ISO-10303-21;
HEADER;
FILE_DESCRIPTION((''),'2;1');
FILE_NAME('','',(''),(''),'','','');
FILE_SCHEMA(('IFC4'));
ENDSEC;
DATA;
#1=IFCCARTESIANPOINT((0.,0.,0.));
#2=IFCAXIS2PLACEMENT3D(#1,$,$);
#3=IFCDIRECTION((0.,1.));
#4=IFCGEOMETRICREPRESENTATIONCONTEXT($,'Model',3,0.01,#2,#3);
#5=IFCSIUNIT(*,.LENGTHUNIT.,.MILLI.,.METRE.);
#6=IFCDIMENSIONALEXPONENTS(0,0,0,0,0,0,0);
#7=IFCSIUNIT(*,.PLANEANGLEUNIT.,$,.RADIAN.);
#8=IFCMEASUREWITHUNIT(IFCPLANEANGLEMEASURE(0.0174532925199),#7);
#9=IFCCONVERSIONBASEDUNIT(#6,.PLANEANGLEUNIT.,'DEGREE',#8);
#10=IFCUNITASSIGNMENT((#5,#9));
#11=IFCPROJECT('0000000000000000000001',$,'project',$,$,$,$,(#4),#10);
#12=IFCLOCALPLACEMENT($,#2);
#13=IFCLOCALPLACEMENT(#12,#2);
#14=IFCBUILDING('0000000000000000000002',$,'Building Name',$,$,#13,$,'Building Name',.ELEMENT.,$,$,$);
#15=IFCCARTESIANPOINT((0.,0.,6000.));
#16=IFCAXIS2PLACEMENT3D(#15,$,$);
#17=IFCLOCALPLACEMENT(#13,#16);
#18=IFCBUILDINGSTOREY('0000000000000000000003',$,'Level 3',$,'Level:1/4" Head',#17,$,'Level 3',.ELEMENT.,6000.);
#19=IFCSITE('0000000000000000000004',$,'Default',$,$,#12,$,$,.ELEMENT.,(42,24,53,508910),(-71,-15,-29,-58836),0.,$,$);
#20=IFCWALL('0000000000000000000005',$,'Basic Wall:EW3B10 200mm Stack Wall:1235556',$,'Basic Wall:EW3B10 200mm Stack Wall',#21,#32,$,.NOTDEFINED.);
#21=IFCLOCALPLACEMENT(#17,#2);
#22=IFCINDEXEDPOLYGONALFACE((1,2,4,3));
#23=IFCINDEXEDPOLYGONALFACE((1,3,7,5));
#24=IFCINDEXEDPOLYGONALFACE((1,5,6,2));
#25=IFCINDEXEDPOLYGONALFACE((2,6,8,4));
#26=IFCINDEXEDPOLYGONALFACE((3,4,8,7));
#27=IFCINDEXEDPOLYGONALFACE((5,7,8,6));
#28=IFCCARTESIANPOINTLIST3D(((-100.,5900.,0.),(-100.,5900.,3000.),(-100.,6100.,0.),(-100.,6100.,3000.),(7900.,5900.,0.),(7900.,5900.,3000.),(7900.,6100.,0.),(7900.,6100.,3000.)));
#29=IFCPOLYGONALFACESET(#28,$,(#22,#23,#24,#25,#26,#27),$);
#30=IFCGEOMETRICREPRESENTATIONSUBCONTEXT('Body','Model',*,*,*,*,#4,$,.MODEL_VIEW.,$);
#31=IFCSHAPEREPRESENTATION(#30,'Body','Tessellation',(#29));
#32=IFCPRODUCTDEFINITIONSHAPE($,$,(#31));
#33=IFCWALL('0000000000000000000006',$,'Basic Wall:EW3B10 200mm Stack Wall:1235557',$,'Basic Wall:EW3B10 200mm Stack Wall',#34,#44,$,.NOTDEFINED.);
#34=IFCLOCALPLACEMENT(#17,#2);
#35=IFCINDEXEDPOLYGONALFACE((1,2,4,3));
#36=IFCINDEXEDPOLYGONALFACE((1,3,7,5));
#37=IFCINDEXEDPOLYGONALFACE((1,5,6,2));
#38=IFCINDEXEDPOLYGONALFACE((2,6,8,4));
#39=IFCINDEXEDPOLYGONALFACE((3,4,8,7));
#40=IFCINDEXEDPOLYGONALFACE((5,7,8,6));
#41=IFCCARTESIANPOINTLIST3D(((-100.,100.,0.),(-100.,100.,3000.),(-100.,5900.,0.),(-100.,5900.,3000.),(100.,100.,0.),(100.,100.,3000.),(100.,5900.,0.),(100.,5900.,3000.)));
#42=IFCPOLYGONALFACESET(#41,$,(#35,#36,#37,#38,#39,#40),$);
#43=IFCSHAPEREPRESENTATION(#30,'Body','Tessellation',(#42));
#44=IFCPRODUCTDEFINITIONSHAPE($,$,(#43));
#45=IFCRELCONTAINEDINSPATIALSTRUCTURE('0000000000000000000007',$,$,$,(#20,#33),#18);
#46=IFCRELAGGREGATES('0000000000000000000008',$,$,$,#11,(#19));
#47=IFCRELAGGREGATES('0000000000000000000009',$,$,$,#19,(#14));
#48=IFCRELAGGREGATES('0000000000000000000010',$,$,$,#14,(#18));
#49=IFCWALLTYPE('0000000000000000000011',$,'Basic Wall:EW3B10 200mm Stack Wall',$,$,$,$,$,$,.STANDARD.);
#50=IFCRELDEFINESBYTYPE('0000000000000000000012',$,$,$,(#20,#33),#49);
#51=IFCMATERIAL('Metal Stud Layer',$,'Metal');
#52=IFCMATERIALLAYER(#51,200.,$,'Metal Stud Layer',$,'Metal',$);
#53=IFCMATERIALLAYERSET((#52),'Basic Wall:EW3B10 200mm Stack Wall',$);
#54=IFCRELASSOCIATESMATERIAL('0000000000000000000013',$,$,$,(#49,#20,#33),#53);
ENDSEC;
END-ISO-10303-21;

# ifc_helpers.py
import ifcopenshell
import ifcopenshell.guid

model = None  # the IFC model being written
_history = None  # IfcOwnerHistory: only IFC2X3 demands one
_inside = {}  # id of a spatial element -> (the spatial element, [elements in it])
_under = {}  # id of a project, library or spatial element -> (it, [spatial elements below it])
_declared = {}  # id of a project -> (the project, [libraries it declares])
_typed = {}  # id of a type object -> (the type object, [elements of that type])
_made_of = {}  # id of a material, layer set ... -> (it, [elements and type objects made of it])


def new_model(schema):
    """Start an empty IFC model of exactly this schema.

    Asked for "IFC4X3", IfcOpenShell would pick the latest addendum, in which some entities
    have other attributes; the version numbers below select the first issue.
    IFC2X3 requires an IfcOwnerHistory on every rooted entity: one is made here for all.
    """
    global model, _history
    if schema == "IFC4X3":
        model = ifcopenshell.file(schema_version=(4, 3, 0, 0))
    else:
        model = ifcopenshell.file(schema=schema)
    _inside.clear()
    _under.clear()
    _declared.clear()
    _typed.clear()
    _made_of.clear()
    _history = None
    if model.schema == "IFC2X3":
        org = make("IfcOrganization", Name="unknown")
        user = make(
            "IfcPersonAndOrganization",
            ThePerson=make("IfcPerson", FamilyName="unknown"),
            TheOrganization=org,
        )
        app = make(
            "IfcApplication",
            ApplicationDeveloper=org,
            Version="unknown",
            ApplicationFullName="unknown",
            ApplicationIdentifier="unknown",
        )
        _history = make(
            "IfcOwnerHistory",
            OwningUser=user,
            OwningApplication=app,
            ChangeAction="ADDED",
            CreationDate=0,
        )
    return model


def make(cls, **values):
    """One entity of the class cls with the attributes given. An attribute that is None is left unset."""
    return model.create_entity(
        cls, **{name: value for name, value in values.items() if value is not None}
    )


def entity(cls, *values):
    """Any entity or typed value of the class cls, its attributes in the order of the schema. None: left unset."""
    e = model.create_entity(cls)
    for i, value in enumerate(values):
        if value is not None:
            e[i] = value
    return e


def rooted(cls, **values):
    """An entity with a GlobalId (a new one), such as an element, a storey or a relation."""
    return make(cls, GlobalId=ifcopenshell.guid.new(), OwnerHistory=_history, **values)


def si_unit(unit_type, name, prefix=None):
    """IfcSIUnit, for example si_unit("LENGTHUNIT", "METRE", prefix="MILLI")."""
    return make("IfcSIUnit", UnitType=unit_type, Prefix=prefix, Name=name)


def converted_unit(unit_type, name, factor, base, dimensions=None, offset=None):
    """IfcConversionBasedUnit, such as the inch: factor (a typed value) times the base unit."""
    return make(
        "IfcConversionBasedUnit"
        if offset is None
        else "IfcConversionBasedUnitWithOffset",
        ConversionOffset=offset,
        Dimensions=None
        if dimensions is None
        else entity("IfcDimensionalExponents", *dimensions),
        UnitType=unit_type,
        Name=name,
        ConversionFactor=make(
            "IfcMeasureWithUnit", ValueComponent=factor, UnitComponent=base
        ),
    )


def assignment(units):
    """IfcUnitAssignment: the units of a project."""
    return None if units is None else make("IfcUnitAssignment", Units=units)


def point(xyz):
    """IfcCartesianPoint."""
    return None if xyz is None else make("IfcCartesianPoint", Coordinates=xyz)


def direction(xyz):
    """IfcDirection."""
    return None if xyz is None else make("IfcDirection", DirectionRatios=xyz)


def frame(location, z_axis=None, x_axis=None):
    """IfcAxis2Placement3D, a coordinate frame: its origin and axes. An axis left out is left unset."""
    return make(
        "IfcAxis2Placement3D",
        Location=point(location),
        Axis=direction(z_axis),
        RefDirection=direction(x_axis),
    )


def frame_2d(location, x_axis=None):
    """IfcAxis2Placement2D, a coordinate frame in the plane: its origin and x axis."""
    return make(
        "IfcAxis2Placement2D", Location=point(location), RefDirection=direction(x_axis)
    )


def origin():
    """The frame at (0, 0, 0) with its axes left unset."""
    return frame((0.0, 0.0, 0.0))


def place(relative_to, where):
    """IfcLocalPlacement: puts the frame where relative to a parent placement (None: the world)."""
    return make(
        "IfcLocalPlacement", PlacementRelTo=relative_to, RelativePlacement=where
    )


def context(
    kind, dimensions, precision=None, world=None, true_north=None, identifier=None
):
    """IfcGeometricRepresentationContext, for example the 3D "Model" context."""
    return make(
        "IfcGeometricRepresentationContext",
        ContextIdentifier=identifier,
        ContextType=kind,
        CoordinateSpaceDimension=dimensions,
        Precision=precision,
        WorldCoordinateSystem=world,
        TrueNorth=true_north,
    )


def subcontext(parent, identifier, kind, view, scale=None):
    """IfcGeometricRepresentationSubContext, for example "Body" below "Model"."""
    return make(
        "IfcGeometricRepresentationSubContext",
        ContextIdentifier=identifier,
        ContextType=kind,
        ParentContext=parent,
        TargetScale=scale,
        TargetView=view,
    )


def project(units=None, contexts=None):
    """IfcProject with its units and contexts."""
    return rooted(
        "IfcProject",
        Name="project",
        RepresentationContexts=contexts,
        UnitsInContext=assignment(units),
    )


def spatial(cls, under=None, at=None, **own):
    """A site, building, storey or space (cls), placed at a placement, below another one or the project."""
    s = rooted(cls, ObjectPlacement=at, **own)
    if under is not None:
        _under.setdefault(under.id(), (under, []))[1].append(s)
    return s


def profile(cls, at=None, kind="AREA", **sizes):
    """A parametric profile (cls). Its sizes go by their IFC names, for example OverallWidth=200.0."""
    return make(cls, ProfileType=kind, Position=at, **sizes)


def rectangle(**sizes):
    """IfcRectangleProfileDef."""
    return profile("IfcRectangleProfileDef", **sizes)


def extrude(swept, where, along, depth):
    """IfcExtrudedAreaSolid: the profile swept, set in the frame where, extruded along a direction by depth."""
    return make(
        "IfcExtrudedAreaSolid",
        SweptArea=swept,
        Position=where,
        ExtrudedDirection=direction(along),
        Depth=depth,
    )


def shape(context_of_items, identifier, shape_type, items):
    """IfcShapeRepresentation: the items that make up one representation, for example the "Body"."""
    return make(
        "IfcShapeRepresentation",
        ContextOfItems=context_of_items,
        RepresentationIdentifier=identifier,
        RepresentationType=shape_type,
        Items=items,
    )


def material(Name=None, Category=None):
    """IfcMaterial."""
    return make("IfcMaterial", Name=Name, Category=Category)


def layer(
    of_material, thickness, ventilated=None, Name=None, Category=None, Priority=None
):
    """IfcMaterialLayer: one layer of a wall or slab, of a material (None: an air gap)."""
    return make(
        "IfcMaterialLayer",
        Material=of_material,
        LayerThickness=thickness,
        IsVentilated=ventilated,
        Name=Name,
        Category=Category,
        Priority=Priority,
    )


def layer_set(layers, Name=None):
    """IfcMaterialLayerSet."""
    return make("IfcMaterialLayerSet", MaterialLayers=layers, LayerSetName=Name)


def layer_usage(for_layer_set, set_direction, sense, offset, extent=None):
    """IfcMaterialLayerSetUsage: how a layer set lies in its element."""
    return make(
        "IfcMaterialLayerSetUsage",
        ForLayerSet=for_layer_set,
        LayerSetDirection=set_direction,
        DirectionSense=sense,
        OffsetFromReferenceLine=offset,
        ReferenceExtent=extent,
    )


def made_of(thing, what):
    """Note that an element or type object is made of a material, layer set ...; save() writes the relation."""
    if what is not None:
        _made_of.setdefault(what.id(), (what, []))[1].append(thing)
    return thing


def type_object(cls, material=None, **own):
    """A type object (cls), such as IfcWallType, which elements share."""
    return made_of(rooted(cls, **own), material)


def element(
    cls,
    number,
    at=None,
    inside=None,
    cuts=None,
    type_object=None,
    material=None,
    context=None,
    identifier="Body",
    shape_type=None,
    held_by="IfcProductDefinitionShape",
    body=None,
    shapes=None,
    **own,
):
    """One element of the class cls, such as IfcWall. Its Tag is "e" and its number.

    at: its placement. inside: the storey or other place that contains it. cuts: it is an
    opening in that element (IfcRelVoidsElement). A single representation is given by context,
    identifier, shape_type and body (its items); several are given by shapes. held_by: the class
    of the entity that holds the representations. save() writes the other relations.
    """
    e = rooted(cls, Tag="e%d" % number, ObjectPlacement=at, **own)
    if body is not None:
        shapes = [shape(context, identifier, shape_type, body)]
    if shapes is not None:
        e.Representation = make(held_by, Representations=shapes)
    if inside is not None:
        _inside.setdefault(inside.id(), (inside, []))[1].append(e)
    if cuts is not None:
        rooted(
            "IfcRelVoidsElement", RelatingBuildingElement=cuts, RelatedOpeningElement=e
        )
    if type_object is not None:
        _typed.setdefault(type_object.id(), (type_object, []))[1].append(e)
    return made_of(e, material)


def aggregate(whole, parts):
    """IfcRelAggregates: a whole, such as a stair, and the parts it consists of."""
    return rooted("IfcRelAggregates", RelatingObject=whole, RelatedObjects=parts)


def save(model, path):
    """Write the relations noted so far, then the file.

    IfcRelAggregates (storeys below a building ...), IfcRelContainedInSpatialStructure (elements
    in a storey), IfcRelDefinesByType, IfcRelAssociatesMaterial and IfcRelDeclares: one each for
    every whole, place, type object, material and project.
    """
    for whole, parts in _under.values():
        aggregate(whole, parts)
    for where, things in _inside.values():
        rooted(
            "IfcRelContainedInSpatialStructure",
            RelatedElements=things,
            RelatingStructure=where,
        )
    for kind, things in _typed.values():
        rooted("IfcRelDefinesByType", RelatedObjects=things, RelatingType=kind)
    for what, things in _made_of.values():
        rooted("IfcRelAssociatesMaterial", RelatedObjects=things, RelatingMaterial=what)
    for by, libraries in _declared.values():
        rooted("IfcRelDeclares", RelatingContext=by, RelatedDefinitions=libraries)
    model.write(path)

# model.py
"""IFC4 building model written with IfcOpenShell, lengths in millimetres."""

from ifc_helpers import new_model, entity, si_unit, converted_unit, direction, frame, frame_2d, origin, place, context, subcontext, project, spatial, rectangle, extrude, material, layer, layer_set, layer_usage, type_object, element, save


model = new_model("IFC4")

# Units and contexts
model_context = context("Model", 3, precision=0.01, world=origin(), true_north=direction((0.0, 1.0)))
body_context = subcontext(model_context, "Body", "Model", "MODEL_VIEW")
ifc_project = project(units=[si_unit("LENGTHUNIT", "METRE", prefix="MILLI"), converted_unit("PLANEANGLEUNIT", "DEGREE", entity("IfcPlaneAngleMeasure", 0.0174532925199), si_unit("PLANEANGLEUNIT", "RADIAN"), dimensions=[0, 0, 0, 0, 0, 0, 0])], contexts=[model_context])

# Site, building, storey
site_placement = place(None, origin())
site = spatial("IfcSite", under=ifc_project, at=site_placement, Name="Default", CompositionType="ELEMENT", RefLatitude=(42, 24, 53, 508910), RefLongitude=(-71, -15, -29, -58836), RefElevation=0.0)
building_placement = place(site_placement, origin())
building = spatial("IfcBuilding", under=site, at=building_placement, Name="Building Name", LongName="Building Name", CompositionType="ELEMENT")
storey_placement = place(building_placement, frame((0.0, 0.0, 6000.0)))
storey = spatial("IfcBuildingStorey", under=building, at=storey_placement, Name="Level 3", ObjectType="Level:1/4\" Head", LongName="Level 3", CompositionType="ELEMENT", Elevation=6000.0)

# Shared definitions
ifc_material_1 = material(Name="Metal Stud Layer", Category="Metal")
ifc_layer_1 = layer(ifc_material_1, 200.0, Name="Metal Stud Layer", Category="Metal")
ifc_layer_set_1 = layer_set([ifc_layer_1], Name="Basic Wall:EW3B10 200mm Stack Wall")
wall_type = type_object("IfcWallType", Name="Basic Wall:EW3B10 200mm Stack Wall", PredefinedType="STANDARD", material=ifc_layer_set_1)

# Walls
ifc_layer_usage_1 = layer_usage(ifc_layer_set_1, "AXIS2", "NEGATIVE", 100.0)
wall_1_placement = place(storey_placement, frame((7900.0, 6000.0, 0.0), z_axis=(0.0, 0.0, 1.0), x_axis=(-1.0, 0.0, 0.0)))
element("IfcWall", 1, at=wall_1_placement, inside=storey, type_object=wall_type, material=ifc_layer_usage_1, Name="Basic Wall:EW3B10 200mm Stack Wall:1235556", ObjectType="Basic Wall:EW3B10 200mm Stack Wall", PredefinedType="NOTDEFINED", context=body_context, shape_type="SweptSolid", body=[
    extrude(rectangle(XDim=8000.0, YDim=200.0, at=frame_2d((4000.0, 0.0), x_axis=(-1.0, 0.0))), origin(), (0.0, 0.0, 1.0), 3000.0),
])
ifc_layer_usage_2 = layer_usage(ifc_layer_set_1, "AXIS2", "NEGATIVE", 100.0)
wall_2_placement = place(storey_placement, frame((0.0, 5900.0, 0.0), z_axis=(0.0, 0.0, 1.0), x_axis=(0.0, -1.0, 0.0)))
element("IfcWall", 2, at=wall_2_placement, inside=storey, type_object=wall_type, material=ifc_layer_usage_2, Name="Basic Wall:EW3B10 200mm Stack Wall:1235557", ObjectType="Basic Wall:EW3B10 200mm Stack Wall", PredefinedType="NOTDEFINED", context=body_context, shape_type="SweptSolid", body=[
    extrude(rectangle(XDim=5800.0, YDim=200.0, at=frame_2d((2900.0, 0.0), x_axis=(-1.0, 0.0))), origin(), (0.0, 0.0, 1.0), 3000.0),
])

save(model, "model.ifc")
